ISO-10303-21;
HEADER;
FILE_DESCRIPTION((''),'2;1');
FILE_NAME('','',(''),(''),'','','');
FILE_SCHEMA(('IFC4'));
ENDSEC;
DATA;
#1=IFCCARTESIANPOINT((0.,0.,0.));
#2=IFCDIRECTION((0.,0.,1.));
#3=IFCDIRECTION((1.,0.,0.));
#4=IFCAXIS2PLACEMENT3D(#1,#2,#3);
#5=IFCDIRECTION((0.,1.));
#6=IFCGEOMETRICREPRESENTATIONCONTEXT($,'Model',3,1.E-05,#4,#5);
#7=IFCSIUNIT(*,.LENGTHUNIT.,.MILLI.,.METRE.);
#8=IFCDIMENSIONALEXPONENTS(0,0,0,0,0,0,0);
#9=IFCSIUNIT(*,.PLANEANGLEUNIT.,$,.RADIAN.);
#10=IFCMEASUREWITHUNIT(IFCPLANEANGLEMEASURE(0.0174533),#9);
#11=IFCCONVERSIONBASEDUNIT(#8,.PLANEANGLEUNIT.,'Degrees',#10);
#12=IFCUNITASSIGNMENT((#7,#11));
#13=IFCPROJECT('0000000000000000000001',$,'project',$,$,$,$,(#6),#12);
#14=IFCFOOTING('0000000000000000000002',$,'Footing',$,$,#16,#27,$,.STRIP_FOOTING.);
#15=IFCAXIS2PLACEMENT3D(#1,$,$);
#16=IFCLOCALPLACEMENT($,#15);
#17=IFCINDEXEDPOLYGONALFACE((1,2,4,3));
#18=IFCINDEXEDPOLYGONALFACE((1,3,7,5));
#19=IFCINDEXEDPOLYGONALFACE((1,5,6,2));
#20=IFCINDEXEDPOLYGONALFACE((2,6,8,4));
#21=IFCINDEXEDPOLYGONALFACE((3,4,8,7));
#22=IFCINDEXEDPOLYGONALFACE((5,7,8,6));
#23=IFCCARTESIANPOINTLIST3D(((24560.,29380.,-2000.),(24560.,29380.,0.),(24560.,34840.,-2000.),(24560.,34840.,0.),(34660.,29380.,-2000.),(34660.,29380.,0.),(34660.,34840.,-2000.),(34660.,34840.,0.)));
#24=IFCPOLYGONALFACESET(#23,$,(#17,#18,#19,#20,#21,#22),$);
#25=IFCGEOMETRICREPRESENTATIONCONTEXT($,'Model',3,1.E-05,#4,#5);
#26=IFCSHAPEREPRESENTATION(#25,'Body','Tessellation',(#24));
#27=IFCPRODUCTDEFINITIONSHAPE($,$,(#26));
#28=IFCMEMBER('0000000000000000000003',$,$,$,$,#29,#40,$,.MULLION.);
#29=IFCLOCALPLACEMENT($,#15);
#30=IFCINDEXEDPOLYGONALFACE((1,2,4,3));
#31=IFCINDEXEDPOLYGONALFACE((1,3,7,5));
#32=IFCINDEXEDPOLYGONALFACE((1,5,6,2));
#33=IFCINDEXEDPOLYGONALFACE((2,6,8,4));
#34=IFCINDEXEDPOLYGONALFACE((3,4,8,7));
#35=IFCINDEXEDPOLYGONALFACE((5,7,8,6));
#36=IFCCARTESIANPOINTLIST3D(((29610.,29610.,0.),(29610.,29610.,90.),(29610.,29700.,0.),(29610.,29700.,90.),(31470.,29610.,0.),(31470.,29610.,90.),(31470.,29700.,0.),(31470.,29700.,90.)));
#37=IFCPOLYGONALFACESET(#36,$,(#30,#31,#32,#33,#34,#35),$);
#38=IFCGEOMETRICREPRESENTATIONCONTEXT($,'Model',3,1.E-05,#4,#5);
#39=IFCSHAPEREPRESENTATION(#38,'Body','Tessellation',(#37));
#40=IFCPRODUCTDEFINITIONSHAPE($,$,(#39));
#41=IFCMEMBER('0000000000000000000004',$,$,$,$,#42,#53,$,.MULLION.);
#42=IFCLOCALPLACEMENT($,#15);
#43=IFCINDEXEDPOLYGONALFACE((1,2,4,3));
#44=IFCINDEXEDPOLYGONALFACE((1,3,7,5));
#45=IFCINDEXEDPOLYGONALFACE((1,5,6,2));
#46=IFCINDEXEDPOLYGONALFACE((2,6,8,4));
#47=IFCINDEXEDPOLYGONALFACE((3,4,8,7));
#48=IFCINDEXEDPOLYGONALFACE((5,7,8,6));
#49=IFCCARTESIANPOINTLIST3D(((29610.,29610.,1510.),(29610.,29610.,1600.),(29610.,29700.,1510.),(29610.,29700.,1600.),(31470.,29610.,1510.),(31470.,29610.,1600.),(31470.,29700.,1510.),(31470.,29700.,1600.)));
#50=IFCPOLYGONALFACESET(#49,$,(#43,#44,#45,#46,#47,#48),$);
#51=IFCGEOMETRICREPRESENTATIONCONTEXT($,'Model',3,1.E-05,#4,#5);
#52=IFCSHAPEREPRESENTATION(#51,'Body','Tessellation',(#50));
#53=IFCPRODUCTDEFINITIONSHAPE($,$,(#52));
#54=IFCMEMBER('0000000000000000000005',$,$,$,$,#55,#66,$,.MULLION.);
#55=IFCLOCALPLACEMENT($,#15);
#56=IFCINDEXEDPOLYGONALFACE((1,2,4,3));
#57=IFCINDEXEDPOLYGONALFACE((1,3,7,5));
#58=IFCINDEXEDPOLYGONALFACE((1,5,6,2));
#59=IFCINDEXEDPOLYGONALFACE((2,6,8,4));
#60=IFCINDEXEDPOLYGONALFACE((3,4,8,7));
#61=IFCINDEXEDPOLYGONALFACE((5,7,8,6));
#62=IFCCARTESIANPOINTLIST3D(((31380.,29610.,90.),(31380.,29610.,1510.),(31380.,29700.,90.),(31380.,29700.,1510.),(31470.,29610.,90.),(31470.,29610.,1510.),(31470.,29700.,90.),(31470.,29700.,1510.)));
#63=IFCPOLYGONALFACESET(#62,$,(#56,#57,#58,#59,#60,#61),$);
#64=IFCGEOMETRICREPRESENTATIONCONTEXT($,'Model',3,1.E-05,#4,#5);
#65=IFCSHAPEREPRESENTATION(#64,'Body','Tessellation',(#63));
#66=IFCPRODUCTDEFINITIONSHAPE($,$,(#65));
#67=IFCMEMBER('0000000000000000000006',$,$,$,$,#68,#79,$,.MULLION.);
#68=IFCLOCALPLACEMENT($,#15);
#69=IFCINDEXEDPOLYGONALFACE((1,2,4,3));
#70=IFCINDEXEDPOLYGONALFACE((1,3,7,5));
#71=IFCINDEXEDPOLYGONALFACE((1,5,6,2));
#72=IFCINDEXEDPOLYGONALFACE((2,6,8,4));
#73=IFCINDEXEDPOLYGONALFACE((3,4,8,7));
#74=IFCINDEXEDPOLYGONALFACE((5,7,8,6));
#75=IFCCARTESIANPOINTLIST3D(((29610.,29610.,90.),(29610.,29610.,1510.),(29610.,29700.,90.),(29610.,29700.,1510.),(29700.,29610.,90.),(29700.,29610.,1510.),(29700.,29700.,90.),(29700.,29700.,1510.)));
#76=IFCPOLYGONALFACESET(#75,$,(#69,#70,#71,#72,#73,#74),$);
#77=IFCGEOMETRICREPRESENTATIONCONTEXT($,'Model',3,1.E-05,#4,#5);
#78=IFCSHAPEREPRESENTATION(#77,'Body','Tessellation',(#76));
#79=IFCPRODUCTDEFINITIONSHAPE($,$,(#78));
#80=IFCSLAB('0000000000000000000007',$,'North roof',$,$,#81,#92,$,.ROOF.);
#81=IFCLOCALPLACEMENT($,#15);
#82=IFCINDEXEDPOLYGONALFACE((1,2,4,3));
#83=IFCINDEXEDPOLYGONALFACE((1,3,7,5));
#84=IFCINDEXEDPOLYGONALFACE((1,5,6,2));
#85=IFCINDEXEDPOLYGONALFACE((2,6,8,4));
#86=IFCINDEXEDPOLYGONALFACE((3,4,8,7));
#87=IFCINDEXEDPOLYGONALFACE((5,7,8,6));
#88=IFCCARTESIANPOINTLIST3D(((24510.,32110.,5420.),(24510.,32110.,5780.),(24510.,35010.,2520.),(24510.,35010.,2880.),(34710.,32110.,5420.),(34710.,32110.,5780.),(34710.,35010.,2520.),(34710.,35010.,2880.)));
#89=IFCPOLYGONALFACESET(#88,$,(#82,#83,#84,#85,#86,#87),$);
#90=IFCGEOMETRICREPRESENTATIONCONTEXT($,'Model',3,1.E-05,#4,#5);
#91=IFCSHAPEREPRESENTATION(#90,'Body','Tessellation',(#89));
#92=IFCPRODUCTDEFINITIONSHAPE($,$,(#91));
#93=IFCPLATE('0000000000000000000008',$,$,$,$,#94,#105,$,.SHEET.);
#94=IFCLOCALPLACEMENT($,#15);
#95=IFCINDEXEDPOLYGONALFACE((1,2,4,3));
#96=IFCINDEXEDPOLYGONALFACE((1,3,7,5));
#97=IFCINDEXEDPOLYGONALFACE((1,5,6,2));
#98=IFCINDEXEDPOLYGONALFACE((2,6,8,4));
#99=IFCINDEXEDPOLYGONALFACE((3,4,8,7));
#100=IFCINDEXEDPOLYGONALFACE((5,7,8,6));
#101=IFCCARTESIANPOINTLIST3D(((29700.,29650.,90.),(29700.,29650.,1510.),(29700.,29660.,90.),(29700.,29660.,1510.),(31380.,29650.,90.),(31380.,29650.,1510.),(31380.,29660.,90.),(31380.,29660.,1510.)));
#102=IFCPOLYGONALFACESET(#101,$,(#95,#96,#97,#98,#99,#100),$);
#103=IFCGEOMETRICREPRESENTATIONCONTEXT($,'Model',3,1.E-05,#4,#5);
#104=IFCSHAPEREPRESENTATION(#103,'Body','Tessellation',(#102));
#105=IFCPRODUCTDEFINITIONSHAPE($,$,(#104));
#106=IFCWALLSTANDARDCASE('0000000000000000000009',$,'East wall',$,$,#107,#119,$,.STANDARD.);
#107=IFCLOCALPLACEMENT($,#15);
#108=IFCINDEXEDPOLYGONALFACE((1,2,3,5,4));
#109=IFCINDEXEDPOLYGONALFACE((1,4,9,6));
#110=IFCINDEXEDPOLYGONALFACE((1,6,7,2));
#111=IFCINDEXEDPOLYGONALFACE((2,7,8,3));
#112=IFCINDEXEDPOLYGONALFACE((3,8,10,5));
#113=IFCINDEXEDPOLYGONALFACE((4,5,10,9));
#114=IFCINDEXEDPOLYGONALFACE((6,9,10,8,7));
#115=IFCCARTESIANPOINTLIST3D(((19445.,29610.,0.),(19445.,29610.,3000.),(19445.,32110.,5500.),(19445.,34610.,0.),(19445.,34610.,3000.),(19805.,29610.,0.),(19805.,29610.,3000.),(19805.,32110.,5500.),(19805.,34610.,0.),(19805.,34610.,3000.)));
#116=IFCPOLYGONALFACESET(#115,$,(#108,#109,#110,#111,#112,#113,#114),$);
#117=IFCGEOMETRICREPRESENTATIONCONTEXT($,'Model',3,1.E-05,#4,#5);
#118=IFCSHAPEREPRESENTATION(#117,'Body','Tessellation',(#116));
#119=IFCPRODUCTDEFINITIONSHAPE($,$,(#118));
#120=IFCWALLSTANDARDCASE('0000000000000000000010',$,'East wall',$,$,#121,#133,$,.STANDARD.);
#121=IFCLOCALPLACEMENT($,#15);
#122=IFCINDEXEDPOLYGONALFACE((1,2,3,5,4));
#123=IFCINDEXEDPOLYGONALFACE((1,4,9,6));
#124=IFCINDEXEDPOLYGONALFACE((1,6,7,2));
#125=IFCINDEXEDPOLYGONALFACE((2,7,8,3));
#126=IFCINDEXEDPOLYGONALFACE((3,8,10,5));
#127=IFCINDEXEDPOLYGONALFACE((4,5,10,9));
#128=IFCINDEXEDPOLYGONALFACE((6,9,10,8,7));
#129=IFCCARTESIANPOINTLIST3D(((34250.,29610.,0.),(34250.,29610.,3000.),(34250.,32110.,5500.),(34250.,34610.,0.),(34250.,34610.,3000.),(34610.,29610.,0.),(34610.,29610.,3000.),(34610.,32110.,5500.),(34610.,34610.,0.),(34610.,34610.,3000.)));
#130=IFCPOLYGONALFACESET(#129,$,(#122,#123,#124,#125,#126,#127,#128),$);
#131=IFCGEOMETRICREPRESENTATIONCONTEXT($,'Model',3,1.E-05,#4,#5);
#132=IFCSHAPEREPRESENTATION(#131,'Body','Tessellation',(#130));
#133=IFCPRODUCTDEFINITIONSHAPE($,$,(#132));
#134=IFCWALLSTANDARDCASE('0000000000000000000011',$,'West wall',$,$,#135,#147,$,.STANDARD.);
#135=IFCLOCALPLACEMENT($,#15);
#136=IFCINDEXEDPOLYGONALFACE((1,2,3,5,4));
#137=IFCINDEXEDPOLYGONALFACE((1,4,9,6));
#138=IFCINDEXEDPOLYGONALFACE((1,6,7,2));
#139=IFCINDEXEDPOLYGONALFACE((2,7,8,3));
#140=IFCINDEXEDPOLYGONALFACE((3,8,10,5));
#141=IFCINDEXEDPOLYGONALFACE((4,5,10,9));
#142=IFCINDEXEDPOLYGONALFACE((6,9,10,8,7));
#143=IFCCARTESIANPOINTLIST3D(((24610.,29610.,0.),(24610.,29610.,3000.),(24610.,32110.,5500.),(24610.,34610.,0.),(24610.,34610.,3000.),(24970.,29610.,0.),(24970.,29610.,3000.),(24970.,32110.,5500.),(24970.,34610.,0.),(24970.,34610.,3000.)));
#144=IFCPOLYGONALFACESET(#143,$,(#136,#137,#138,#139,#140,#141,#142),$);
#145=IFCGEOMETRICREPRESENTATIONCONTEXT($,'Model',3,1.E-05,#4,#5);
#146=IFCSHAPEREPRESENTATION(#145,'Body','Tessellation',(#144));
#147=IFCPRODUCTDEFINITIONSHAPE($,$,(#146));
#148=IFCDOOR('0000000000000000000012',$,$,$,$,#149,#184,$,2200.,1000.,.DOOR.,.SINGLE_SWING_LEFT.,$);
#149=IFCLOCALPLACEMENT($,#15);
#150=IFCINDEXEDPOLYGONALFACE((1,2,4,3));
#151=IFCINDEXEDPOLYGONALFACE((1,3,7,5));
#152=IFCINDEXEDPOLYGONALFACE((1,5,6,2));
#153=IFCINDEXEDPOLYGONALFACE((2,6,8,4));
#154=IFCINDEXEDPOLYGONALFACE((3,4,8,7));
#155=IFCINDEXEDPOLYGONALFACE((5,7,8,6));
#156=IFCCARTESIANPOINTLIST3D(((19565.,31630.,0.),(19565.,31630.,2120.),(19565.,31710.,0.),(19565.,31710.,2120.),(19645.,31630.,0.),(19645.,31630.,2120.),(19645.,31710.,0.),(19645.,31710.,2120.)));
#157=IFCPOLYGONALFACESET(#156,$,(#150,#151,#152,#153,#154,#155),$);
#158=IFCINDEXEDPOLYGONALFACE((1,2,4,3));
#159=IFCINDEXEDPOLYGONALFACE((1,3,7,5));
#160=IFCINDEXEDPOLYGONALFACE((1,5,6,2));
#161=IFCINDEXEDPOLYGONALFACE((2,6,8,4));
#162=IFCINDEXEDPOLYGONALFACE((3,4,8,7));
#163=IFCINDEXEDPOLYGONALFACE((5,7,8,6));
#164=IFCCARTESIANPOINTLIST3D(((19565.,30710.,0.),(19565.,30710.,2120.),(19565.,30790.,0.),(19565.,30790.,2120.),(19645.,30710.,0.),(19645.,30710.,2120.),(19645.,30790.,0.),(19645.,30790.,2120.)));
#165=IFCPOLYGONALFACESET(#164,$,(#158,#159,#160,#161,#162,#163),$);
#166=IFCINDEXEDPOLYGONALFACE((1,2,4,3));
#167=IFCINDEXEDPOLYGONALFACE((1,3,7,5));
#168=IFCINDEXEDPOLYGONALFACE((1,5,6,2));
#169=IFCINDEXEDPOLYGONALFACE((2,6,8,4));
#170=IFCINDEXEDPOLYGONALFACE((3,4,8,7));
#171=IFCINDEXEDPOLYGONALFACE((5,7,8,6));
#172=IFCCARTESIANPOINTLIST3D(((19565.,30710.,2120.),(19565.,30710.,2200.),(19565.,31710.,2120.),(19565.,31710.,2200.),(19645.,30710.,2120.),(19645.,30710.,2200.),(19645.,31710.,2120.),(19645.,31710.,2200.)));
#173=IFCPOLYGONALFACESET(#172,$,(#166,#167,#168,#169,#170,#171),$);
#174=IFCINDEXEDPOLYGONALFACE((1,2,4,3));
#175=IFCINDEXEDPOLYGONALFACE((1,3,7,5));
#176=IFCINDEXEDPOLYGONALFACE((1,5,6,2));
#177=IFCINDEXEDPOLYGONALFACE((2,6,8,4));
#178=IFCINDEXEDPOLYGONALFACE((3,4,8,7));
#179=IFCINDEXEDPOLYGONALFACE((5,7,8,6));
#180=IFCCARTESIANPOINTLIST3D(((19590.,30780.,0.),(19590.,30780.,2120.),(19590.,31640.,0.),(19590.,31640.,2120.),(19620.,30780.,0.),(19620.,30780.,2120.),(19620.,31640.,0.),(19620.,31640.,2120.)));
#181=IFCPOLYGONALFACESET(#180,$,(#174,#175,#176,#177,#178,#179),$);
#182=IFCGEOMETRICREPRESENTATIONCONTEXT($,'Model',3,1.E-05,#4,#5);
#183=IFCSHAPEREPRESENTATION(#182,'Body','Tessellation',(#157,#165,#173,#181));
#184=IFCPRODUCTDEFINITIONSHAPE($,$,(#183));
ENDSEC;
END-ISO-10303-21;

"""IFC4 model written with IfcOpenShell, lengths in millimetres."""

from ifc_helpers import new_model, entity, si_unit, converted_unit, direction, frame, origin_with_axes, place, context, project, polyline, outline, extrude, clip, halfspace, source, transform, mapped, element, save


model = new_model("IFC4")

# Units and contexts
model_context_1 = context("Model", 3, precision=1e-05, world=origin_with_axes(), true_north=direction((0.0, 1.0)))
model_context_2 = context("Model", 3, precision=1e-05, world=origin_with_axes(), true_north=direction((0.0, 1.0)))
model_context_3 = context("Model", 3, precision=1e-05, world=origin_with_axes(), true_north=direction((0.0, 1.0)))
model_context_4 = context("Model", 3, precision=1e-05, world=origin_with_axes(), true_north=direction((0.0, 1.0)))
model_context_5 = context("Model", 3, precision=1e-05, world=origin_with_axes(), true_north=direction((0.0, 1.0)))
model_context_6 = context("Model", 3, precision=1e-05, world=origin_with_axes(), true_north=direction((0.0, 1.0)))
model_context_7 = context("Model", 3, precision=1e-05, world=origin_with_axes(), true_north=direction((0.0, 1.0)))
model_context_8 = context("Model", 3, precision=1e-05, world=origin_with_axes(), true_north=direction((0.0, 1.0)))
model_context_9 = context("Model", 3, precision=1e-05, world=origin_with_axes(), true_north=direction((0.0, 1.0)))
model_context_10 = context("Model", 3, precision=1e-05, world=origin_with_axes(), true_north=direction((0.0, 1.0)))
model_context_11 = context("Model", 3, precision=1e-05, world=origin_with_axes(), true_north=direction((0.0, 1.0)))
model_context_12 = context("Model", 3, precision=1e-05, world=origin_with_axes(), true_north=direction((0.0, 1.0)))
ifc_project = project(units=[si_unit("LENGTHUNIT", "METRE", prefix="MILLI"), converted_unit("PLANEANGLEUNIT", "Degrees", entity("IfcPlaneAngleMeasure", 0.0174533), si_unit("PLANEANGLEUNIT", "RADIAN"), dimensions=[0, 0, 0, 0, 0, 0, 0])], contexts=[model_context_1])

# Footing
placement_1 = place(None, frame((29610.0, 29610.0, 0.0)))
footing_placement = place(placement_1, frame((0.0, 2500.0, -2000.0), z_axis=(0.0, 0.0, 1.0), x_axis=(1.0, 0.0, 0.0)))
element("IfcFooting", 1, at=footing_placement, Name="Footing", PredefinedType="STRIP_FOOTING", context=model_context_4, shape_type="SweptSolid", body=[
    extrude(outline(polyline([(-5050.0, -2730.0), (5050.0, -2730.0), (5050.0, 2730.0), (-5050.0, 2730.0), (-5050.0, -2730.0), (-5050.0, -2730.0)])), origin_with_axes(), (0.0, 0.0, 1.0), 2000.0),
])

# Members
shared_shape_1 = source(origin_with_axes(), model_context_5, "Body", "SweptSolid", [
    extrude(outline(polyline([(-930.0, -45.0), (930.0, -45.0), (930.0, 45.0), (-930.0, 45.0), (-930.0, -45.0), (-930.0, -45.0)])), origin_with_axes(), (0.0, 0.0, 1.0), 90.0),
])
member_1_placement = place(placement_1, frame((930.0, 45.0, 0.0), z_axis=(0.0, 0.0, 1.0), x_axis=(1.0, 0.0, 0.0)))
element("IfcMember", 2, at=member_1_placement, PredefinedType="MULLION", context=model_context_5, shape_type="MappedRepresentation", body=[
    mapped(shared_shape_1, transform((0.0, 0.0, 0.0))),
])
shared_shape_2 = source(origin_with_axes(), model_context_6, "Body", "SweptSolid", [
    extrude(outline(polyline([(-930.0, -45.0), (930.0, -45.0), (930.0, 45.0), (-930.0, 45.0), (-930.0, -45.0), (-930.0, -45.0)])), origin_with_axes(), (0.0, 0.0, 1.0), 90.0),
])
member_2_placement = place(placement_1, frame((930.0, 45.0, 1510.0), z_axis=(0.0, 0.0, 1.0), x_axis=(1.0, 0.0, 0.0)))
element("IfcMember", 3, at=member_2_placement, PredefinedType="MULLION", context=model_context_6, shape_type="MappedRepresentation", body=[
    mapped(shared_shape_2, transform((0.0, 0.0, 0.0))),
])
shared_shape_3 = source(origin_with_axes(), model_context_7, "Body", "SweptSolid", [
    extrude(outline(polyline([(-45.0, -45.0), (45.0, -45.0), (45.0, 45.0), (-45.0, 45.0), (-45.0, -45.0), (-45.0, -45.0)])), origin_with_axes(), (0.0, 0.0, 1.0), 1420.0),
])
member_3_placement = place(placement_1, frame((1815.0, 45.0, 90.0), z_axis=(0.0, 0.0, 1.0), x_axis=(1.0, 0.0, 0.0)))
element("IfcMember", 4, at=member_3_placement, PredefinedType="MULLION", context=model_context_7, shape_type="MappedRepresentation", body=[
    mapped(shared_shape_3, transform((0.0, 0.0, 0.0))),
])
shared_shape_4 = source(origin_with_axes(), model_context_8, "Body", "SweptSolid", [
    extrude(outline(polyline([(-45.0, -45.0), (45.0, -45.0), (45.0, 45.0), (-45.0, 45.0), (-45.0, -45.0), (-45.0, -45.0)])), origin_with_axes(), (0.0, 0.0, 1.0), 1420.0),
])
member_4_placement = place(placement_1, frame((45.0, 45.0, 90.0), z_axis=(0.0, 0.0, 1.0), x_axis=(1.0, 0.0, 0.0)))
element("IfcMember", 5, at=member_4_placement, PredefinedType="MULLION", context=model_context_8, shape_type="MappedRepresentation", body=[
    mapped(shared_shape_4, transform((0.0, 0.0, 0.0))),
])

# Slab
shared_shape_5 = source(origin_with_axes(), model_context_10, "Body", "SweptSolid", [
    extrude(outline(polyline([(-5100.0, -180.0), (5100.0, -180.0), (5100.0, 180.0), (-5100.0, 180.0), (-5100.0, -180.0), (-5100.0, -180.0)])), frame((0.0, 0.0, 0.0), z_axis=(0.0, 1.0, 0.0), x_axis=(1.0, 0.0, 0.0)), (0.0, -0.707107, 0.707107), 4101.2),
])
slab_placement = place(placement_1, frame((0.0, 5400.0, 2700.0), z_axis=(0.0, 0.0, 1.0), x_axis=(-1.0, 0.0, 0.0)))
element("IfcSlab", 6, at=slab_placement, Name="North roof", PredefinedType="ROOF", context=model_context_10, shape_type="MappedRepresentation", body=[
    mapped(shared_shape_5, transform((0.0, 0.0, 0.0))),
])

# Plate
plate_1_placement = place(placement_1, frame((930.0, 45.0, 90.0), z_axis=(0.0, 0.0, 1.0), x_axis=(1.0, 0.0, 0.0)))
element("IfcPlate", 7, at=plate_1_placement, PredefinedType="SHEET", context=model_context_9, shape_type="SweptSolid", body=[
    extrude(outline(polyline([(-840.0, -5.0), (840.0, -5.0), (840.0, 5.0), (-840.0, 5.0), (-840.0, -5.0), (-840.0, -5.0)])), origin_with_axes(), (0.0, 0.0, 1.0), 1420.0),
])

# Walls
shared_shape_6 = source(origin_with_axes(), model_context_3, "Body", "Clipping", [
    clip(clip(extrude(outline(polyline([(-2500.0, -180.0), (2500.0, -180.0), (2500.0, 180.0), (-2500.0, 180.0), (-2500.0, -180.0), (-2500.0, -180.0)])), origin_with_axes(), (0.0, 0.0, 1.0), 6000.0), halfspace(frame((-2500.0, 0.0, 3000.0), z_axis=(-1.0, 0.0, 1.0), x_axis=(1.0, 0.0, 0.0)), False)), halfspace(frame((2500.0, 0.0, 3000.0), z_axis=(1.0, 0.0, 1.0), x_axis=(1.0, 0.0, 0.0)), False)),
])
placement_2 = place(None, frame((14805.0, 29610.0, 0.0)))
wall_1_placement = place(placement_2, frame((4820.0, 2500.0, 0.0), z_axis=(0.0, 0.0, 1.0), x_axis=(0.0, 1.0, 0.0)))
element("IfcWallStandardCase", 8, at=wall_1_placement, Name="East wall", PredefinedType="STANDARD", context=model_context_3, shape_type="MappedRepresentation", body=[
    mapped(shared_shape_6, transform((0.0, 0.0, 0.0))),
])
shared_shape_7 = source(origin_with_axes(), model_context_11, "Body", "Clipping", [
    clip(clip(extrude(outline(polyline([(-2500.0, -180.0), (2500.0, -180.0), (2500.0, 180.0), (-2500.0, 180.0), (-2500.0, -180.0), (-2500.0, -180.0)])), origin_with_axes(), (0.0, 0.0, 1.0), 6000.0), halfspace(frame((-2500.0, 0.0, 3000.0), z_axis=(-1.0, 0.0, 1.0), x_axis=(1.0, 0.0, 0.0)), False)), halfspace(frame((2500.0, 0.0, 3000.0), z_axis=(1.0, 0.0, 1.0), x_axis=(1.0, 0.0, 0.0)), False)),
])
wall_2_placement = place(placement_1, frame((4820.0, 2500.0, 0.0), z_axis=(0.0, 0.0, 1.0), x_axis=(0.0, 1.0, 0.0)))
element("IfcWallStandardCase", 9, at=wall_2_placement, Name="East wall", PredefinedType="STANDARD", context=model_context_11, shape_type="MappedRepresentation", body=[
    mapped(shared_shape_7, transform((0.0, 0.0, 0.0))),
])
shared_shape_8 = source(origin_with_axes(), model_context_12, "Body", "Clipping", [
    clip(clip(extrude(outline(polyline([(-2500.0, -180.0), (2500.0, -180.0), (2500.0, 180.0), (-2500.0, 180.0), (-2500.0, -180.0), (-2500.0, -180.0)])), origin_with_axes(), (0.0, 0.0, 1.0), 6000.0), halfspace(frame((-2500.0, 0.0, 3000.0), z_axis=(-1.0, 0.0, 1.0), x_axis=(1.0, 0.0, 0.0)), False)), halfspace(frame((2500.0, 0.0, 3000.0), z_axis=(1.0, 0.0, 1.0), x_axis=(1.0, 0.0, 0.0)), False)),
])
wall_3_placement = place(placement_1, frame((-4820.0, 2500.0, 0.0), z_axis=(0.0, 0.0, 1.0), x_axis=(0.0, -1.0, 0.0)))
element("IfcWallStandardCase", 10, at=wall_3_placement, Name="West wall", PredefinedType="STANDARD", context=model_context_12, shape_type="MappedRepresentation", body=[
    mapped(shared_shape_8, transform((0.0, 0.0, 0.0))),
])

# Door
door_1_placement = place(placement_2, frame((4800.0, 1600.0, 0.0), z_axis=(0.0, 0.0, 1.0), x_axis=(0.0, 1.0, 0.0)))
element("IfcDoor", 11, at=door_1_placement, OperationType="SINGLE_SWING_LEFT", OverallHeight=2200.0, OverallWidth=1000.0, PredefinedType="DOOR", context=model_context_2, shape_type="SweptSolid", body=[
    extrude(outline(polyline([(-40.0, -40.0), (40.0, -40.0), (40.0, 40.0), (-40.0, 40.0), (-40.0, -40.0), (-40.0, -40.0)])), frame((460.0, 0.0, 0.0), z_axis=(0.0, 0.0, 1.0), x_axis=(1.0, 0.0, 0.0)), (0.0, 0.0, 1.0), 2120.0),
    extrude(outline(polyline([(-40.0, -40.0), (40.0, -40.0), (40.0, 40.0), (-40.0, 40.0), (-40.0, -40.0), (-40.0, -40.0)])), frame((-460.0, 0.0, 0.0), z_axis=(0.0, 0.0, 1.0), x_axis=(1.0, 0.0, 0.0)), (0.0, 0.0, 1.0), 2120.0),
    extrude(outline(polyline([(-500.0, -40.0), (500.0, -40.0), (500.0, 40.0), (-500.0, 40.0), (-500.0, -40.0), (-500.0, -40.0)])), frame((0.0, 0.0, 2120.0), z_axis=(0.0, 0.0, 1.0), x_axis=(1.0, 0.0, 0.0)), (0.0, 0.0, 1.0), 80.0),
    extrude(outline(polyline([(-430.0, -15.0), (430.0, -15.0), (430.0, 15.0), (-430.0, 15.0), (-430.0, -15.0), (-430.0, -15.0)])), origin_with_axes(), (0.0, 0.0, 1.0), 2120.0),
])

save(model, "model.ifc")
